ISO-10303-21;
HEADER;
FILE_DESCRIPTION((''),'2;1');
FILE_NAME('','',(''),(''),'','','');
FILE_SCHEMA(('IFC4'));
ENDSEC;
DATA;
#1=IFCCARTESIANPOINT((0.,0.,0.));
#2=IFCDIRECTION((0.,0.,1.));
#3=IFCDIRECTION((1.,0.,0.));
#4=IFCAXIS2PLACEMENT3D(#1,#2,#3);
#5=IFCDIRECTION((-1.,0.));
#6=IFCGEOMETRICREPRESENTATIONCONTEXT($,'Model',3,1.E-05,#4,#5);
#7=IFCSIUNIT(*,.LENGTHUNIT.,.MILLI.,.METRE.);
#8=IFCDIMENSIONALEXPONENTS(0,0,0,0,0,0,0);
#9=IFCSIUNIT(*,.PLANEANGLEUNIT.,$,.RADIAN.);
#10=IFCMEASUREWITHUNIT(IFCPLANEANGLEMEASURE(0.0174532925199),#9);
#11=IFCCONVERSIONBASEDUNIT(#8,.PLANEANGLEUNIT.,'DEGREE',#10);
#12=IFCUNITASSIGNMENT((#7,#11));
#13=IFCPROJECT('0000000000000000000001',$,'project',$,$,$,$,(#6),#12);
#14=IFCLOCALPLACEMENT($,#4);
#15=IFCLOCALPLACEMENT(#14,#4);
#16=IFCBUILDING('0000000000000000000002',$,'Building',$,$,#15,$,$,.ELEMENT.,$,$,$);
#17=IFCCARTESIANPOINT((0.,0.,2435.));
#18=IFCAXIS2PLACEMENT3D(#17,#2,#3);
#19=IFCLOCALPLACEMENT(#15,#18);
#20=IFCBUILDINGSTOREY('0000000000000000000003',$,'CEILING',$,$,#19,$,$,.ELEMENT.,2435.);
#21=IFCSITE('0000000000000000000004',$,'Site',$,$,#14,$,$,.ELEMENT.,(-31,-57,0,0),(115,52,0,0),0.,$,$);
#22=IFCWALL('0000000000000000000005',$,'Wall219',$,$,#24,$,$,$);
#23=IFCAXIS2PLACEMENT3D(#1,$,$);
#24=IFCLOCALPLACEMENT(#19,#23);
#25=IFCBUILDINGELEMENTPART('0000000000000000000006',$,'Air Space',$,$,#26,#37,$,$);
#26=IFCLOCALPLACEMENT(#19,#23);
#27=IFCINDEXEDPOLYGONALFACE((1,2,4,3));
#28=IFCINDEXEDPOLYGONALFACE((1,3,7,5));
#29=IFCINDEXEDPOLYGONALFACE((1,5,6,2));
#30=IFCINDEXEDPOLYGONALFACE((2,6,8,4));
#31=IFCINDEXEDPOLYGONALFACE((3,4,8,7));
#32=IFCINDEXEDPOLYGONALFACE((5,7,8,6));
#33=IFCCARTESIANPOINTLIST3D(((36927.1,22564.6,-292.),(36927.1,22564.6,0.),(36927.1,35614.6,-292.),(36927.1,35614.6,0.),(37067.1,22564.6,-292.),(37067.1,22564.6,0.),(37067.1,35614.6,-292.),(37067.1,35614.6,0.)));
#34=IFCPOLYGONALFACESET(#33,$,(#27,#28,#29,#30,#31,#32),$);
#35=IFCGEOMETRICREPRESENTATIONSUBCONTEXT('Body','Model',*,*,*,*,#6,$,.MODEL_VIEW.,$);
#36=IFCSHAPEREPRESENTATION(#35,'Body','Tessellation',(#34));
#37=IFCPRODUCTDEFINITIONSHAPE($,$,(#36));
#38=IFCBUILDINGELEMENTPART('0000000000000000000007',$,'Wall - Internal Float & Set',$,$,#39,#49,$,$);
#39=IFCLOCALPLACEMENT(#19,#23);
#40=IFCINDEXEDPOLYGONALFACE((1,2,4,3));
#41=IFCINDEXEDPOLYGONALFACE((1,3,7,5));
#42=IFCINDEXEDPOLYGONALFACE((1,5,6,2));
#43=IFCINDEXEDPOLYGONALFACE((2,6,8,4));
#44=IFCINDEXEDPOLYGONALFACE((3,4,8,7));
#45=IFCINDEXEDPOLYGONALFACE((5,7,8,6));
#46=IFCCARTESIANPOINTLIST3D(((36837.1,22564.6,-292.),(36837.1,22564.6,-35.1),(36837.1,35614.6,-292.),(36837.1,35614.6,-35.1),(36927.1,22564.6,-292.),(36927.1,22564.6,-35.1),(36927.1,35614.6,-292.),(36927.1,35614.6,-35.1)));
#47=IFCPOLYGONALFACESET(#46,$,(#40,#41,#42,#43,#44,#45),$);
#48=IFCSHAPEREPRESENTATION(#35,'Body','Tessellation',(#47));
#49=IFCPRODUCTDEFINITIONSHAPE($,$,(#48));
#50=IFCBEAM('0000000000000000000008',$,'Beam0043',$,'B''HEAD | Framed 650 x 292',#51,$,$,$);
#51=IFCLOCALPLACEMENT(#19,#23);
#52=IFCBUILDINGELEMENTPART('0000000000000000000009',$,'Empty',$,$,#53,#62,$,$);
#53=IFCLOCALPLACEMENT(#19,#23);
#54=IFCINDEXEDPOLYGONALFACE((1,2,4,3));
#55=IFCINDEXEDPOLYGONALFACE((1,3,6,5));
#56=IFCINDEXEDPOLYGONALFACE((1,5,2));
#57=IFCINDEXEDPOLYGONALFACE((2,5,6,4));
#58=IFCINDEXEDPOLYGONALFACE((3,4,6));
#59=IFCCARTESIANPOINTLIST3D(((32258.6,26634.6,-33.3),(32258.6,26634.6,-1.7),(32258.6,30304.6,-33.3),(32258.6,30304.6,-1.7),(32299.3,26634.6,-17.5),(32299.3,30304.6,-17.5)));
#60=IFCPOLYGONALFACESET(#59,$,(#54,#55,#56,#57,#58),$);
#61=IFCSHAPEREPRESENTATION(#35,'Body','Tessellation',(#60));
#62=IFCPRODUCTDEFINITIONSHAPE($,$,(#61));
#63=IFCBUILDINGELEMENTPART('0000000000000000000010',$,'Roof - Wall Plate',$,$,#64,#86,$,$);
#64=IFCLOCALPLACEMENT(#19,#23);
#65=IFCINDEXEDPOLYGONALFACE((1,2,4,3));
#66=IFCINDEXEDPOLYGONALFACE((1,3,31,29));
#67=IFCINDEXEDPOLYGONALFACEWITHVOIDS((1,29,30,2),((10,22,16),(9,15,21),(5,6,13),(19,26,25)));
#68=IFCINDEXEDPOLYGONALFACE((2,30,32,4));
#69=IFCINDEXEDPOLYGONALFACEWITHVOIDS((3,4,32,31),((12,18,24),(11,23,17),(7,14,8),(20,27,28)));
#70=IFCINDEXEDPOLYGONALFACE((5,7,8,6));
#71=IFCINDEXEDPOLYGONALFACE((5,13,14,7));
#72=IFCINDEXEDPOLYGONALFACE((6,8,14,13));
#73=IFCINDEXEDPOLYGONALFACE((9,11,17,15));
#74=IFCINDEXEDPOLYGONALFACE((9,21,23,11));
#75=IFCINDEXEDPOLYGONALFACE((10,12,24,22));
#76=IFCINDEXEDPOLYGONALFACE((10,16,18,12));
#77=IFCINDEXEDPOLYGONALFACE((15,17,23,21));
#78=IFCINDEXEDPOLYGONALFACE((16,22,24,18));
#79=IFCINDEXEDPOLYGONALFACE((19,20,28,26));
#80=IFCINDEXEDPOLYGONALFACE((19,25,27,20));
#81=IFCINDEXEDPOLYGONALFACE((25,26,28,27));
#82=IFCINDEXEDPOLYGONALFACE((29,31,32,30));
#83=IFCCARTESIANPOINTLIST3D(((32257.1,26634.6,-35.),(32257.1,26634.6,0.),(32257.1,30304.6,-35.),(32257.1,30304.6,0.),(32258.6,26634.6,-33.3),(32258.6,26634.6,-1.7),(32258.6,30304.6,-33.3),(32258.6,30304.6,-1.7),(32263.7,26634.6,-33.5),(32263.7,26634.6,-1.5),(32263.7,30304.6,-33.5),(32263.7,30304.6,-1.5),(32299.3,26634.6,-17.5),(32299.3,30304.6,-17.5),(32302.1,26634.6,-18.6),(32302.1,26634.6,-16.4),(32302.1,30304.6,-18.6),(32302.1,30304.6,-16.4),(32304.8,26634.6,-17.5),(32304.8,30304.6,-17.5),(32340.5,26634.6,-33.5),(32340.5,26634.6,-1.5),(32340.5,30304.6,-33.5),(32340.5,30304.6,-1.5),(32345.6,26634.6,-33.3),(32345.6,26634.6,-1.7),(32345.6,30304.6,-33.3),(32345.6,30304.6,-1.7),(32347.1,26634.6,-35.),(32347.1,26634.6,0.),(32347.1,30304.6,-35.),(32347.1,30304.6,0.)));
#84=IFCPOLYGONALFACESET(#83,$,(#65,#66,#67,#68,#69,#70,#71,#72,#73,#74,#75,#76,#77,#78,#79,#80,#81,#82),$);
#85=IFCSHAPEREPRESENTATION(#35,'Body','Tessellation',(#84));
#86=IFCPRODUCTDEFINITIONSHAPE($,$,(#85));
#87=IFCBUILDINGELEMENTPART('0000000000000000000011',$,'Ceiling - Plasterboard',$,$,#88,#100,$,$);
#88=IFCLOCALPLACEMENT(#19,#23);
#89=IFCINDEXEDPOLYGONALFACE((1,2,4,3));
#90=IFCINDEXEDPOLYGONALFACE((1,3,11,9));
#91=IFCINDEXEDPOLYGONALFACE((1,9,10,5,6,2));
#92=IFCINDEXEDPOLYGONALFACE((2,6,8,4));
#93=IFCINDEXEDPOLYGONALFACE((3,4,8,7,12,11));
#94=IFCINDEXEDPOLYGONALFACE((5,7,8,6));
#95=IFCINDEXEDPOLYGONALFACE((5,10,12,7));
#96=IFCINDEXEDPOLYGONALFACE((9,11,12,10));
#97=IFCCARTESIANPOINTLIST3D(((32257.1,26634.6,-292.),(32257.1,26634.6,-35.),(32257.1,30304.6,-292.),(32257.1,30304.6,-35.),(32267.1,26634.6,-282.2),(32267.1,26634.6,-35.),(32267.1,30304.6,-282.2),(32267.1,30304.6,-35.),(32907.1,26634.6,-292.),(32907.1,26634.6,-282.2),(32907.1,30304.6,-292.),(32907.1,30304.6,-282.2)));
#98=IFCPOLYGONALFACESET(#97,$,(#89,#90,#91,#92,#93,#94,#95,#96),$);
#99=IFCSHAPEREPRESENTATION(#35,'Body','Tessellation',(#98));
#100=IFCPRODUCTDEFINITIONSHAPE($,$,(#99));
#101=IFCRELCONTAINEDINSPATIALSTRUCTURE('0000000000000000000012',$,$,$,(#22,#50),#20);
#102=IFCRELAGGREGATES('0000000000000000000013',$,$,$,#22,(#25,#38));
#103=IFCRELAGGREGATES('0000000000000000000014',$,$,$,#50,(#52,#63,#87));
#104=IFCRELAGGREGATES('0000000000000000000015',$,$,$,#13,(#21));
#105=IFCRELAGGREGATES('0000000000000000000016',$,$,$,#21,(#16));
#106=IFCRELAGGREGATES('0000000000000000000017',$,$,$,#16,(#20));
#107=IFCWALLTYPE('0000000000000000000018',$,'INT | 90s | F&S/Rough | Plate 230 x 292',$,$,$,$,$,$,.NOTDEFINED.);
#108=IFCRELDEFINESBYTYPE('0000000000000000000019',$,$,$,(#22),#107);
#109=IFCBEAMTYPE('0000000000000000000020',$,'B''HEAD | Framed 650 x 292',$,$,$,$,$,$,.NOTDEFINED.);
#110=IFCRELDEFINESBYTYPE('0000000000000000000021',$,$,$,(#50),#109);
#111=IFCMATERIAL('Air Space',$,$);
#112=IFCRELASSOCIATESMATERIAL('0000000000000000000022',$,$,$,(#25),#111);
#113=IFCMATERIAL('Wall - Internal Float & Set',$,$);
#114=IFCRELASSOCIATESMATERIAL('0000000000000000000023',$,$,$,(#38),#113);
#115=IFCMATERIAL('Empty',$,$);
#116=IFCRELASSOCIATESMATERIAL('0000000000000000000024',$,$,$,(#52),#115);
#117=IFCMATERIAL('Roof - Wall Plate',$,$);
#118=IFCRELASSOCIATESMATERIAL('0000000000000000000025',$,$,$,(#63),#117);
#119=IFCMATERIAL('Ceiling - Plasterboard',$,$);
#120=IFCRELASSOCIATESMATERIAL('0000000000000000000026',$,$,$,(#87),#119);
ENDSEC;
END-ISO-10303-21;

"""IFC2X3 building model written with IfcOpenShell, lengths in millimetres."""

from ifc_helpers import new_model, entity, si_unit, converted_unit, direction, frame, origin_with_axes, place, context, subcontext, project, spatial, polyline, outline, extrude, material, type_object, element, aggregate, save


model = new_model("IFC2X3")

# Units and contexts
model_context = context("Model", 3, precision=1e-05, world=origin_with_axes(), true_north=direction((-1.0, 0.0)))
body_context = subcontext(model_context, "Body", "Model", "MODEL_VIEW")
ifc_project = project(units=[si_unit("LENGTHUNIT", "METRE", prefix="MILLI"), converted_unit("PLANEANGLEUNIT", "DEGREE", entity("IfcPlaneAngleMeasure", 0.0174532925199), si_unit("PLANEANGLEUNIT", "RADIAN"), dimensions=[0, 0, 0, 0, 0, 0, 0])], contexts=[model_context])

# Site, building, storey
site_placement = place(None, origin_with_axes())
site = spatial("IfcSite", under=ifc_project, at=site_placement, Name="Site", CompositionType="ELEMENT", RefLatitude=(-31, -57, 0, 0), RefLongitude=(115, 52, 0, 0), RefElevation=0.0)
building_placement = place(site_placement, origin_with_axes())
building = spatial("IfcBuilding", under=site, at=building_placement, Name="Building", CompositionType="ELEMENT")
storey_placement = place(building_placement, frame((0.0, 0.0, 2435.0), z_axis=(0.0, 0.0, 1.0), x_axis=(1.0, 0.0, 0.0)))
storey = spatial("IfcBuildingStorey", under=building, at=storey_placement, Name="CEILING", CompositionType="ELEMENT", Elevation=2435.0)

# Shared definitions
ifc_material_1 = material(Name="Ceiling - Plasterboard")
ifc_material_2 = material(Name="Air Space")

# Wall, building element parts
wall_type = type_object("IfcWallType", Name="INT | 90s | F&S/Rough | Plate 230 x 292", PredefinedType="NOTDEFINED")
ifc_material_3 = material(Name="Empty")
ifc_material_4 = material(Name="Wall - Internal Float & Set")
wall_1_placement = place(storey_placement, frame((36927.1, 35614.6, -292.0), z_axis=(0.0, 0.0, 1.0), x_axis=(0.0, -1.0, 0.0)))
wall_1 = element("IfcWall", 1, at=wall_1_placement, inside=storey, type_object=wall_type, Name="Wall219")
building_element_part_1_placement = place(wall_1_placement, origin_with_axes())
building_element_part_1 = element("IfcBuildingElementPart", 2, at=building_element_part_1_placement, material=ifc_material_2, Name="Air Space", context=body_context, shape_type="SweptSolid", body=[
    extrude(outline(polyline([(0.0, 292.0), (0.0, 0.0), (140.0, 0.0), (140.0, 292.0), (0.0, 292.0)])), frame((0.0, 0.0, 0.0), z_axis=(1.0, 0.0, 0.0), x_axis=(0.0, 1.0, 0.0)), (0.0, 0.0, 1.0), 13050.0),
])
ifc_material_5 = material(Name="Roof - Wall Plate")
building_element_part_2_placement = place(wall_1_placement, origin_with_axes())
building_element_part_2 = element("IfcBuildingElementPart", 3, at=building_element_part_2_placement, material=ifc_material_4, Name="Wall - Internal Float & Set", context=body_context, shape_type="SweptSolid", body=[
    extrude(outline(polyline([(-90.0, 256.9), (-90.0, 0.0), (0.0, 0.0), (0.0, 256.9), (-90.0, 256.9)])), frame((0.0, 0.0, 0.0), z_axis=(1.0, 0.0, 0.0), x_axis=(0.0, 1.0, 0.0)), (0.0, 0.0, 1.0), 13050.0),
])
aggregate(wall_1, [building_element_part_1, building_element_part_2])

# Beam, building element parts
beam_type = type_object("IfcBeamType", Name="B'HEAD | Framed 650 x 292", PredefinedType="NOTDEFINED")
beam_placement = place(storey_placement, frame((32257.1, 30304.6, 0.0), z_axis=(0.0, 0.0, 1.0), x_axis=(-1.0, 0.0, 0.0)))
beam = element("IfcBeam", 4, at=beam_placement, inside=storey, type_object=beam_type, Name="Beam0043", ObjectType="B'HEAD | Framed 650 x 292")
building_element_part_3_placement = place(beam_placement, origin_with_axes())
building_element_part_3 = element("IfcBuildingElementPart", 5, at=building_element_part_3_placement, material=ifc_material_3, Name="Empty", context=body_context, shape_type="SweptSolid", body=[
    extrude(outline(polyline([(-42.2, -17.5), (-1.5, -33.3), (-1.5, -1.7), (-42.2, -17.5)])), frame((0.0, 3670.0, 0.0), z_axis=(0.0, -1.0, 0.0), x_axis=(1.0, 0.0, 0.0)), (0.0, 0.0, 1.0), 3670.0),
])
building_element_part_4_placement = place(beam_placement, origin_with_axes())
building_element_part_4 = element("IfcBuildingElementPart", 6, at=building_element_part_4_placement, material=ifc_material_5, Name="Roof - Wall Plate", context=body_context, shape_type="SweptSolid", body=[
    extrude(outline(polyline([(-90.0, -35.0), (0.0, -35.0), (0.0, 0.0), (-90.0, 0.0), (-90.0, -35.0)]), holes=[polyline([(-88.5, -1.7), (-47.8, -17.5), (-88.5, -33.3), (-88.5, -1.7)]), polyline([(-6.6, -33.5), (-83.4, -33.5), (-45.0, -18.6), (-6.6, -33.5)]), polyline([(-83.4, -1.5), (-6.6, -1.5), (-45.0, -16.4), (-83.4, -1.5)]), polyline([(-42.2, -17.5), (-1.5, -1.7), (-1.5, -33.3), (-42.2, -17.5)])]), frame((0.0, 3670.0, 0.0), z_axis=(0.0, -1.0, 0.0), x_axis=(1.0, 0.0, 0.0)), (0.0, 0.0, 1.0), 3670.0),
])
building_element_part_5_placement = place(beam_placement, origin_with_axes())
building_element_part_5 = element("IfcBuildingElementPart", 7, at=building_element_part_5_placement, material=ifc_material_1, Name="Ceiling - Plasterboard", context=body_context, shape_type="SweptSolid", body=[
    extrude(outline(polyline([(-10.0, -282.2), (-650.0, -282.2), (-650.0, -292.0), (0.0, -292.0), (0.0, -35.0), (-10.0, -35.0), (-10.0, -282.2)])), frame((0.0, 3670.0, 0.0), z_axis=(0.0, -1.0, 0.0), x_axis=(1.0, 0.0, 0.0)), (0.0, 0.0, 1.0), 3670.0),
])
aggregate(beam, [building_element_part_3, building_element_part_4, building_element_part_5])

save(model, "model.ifc")
